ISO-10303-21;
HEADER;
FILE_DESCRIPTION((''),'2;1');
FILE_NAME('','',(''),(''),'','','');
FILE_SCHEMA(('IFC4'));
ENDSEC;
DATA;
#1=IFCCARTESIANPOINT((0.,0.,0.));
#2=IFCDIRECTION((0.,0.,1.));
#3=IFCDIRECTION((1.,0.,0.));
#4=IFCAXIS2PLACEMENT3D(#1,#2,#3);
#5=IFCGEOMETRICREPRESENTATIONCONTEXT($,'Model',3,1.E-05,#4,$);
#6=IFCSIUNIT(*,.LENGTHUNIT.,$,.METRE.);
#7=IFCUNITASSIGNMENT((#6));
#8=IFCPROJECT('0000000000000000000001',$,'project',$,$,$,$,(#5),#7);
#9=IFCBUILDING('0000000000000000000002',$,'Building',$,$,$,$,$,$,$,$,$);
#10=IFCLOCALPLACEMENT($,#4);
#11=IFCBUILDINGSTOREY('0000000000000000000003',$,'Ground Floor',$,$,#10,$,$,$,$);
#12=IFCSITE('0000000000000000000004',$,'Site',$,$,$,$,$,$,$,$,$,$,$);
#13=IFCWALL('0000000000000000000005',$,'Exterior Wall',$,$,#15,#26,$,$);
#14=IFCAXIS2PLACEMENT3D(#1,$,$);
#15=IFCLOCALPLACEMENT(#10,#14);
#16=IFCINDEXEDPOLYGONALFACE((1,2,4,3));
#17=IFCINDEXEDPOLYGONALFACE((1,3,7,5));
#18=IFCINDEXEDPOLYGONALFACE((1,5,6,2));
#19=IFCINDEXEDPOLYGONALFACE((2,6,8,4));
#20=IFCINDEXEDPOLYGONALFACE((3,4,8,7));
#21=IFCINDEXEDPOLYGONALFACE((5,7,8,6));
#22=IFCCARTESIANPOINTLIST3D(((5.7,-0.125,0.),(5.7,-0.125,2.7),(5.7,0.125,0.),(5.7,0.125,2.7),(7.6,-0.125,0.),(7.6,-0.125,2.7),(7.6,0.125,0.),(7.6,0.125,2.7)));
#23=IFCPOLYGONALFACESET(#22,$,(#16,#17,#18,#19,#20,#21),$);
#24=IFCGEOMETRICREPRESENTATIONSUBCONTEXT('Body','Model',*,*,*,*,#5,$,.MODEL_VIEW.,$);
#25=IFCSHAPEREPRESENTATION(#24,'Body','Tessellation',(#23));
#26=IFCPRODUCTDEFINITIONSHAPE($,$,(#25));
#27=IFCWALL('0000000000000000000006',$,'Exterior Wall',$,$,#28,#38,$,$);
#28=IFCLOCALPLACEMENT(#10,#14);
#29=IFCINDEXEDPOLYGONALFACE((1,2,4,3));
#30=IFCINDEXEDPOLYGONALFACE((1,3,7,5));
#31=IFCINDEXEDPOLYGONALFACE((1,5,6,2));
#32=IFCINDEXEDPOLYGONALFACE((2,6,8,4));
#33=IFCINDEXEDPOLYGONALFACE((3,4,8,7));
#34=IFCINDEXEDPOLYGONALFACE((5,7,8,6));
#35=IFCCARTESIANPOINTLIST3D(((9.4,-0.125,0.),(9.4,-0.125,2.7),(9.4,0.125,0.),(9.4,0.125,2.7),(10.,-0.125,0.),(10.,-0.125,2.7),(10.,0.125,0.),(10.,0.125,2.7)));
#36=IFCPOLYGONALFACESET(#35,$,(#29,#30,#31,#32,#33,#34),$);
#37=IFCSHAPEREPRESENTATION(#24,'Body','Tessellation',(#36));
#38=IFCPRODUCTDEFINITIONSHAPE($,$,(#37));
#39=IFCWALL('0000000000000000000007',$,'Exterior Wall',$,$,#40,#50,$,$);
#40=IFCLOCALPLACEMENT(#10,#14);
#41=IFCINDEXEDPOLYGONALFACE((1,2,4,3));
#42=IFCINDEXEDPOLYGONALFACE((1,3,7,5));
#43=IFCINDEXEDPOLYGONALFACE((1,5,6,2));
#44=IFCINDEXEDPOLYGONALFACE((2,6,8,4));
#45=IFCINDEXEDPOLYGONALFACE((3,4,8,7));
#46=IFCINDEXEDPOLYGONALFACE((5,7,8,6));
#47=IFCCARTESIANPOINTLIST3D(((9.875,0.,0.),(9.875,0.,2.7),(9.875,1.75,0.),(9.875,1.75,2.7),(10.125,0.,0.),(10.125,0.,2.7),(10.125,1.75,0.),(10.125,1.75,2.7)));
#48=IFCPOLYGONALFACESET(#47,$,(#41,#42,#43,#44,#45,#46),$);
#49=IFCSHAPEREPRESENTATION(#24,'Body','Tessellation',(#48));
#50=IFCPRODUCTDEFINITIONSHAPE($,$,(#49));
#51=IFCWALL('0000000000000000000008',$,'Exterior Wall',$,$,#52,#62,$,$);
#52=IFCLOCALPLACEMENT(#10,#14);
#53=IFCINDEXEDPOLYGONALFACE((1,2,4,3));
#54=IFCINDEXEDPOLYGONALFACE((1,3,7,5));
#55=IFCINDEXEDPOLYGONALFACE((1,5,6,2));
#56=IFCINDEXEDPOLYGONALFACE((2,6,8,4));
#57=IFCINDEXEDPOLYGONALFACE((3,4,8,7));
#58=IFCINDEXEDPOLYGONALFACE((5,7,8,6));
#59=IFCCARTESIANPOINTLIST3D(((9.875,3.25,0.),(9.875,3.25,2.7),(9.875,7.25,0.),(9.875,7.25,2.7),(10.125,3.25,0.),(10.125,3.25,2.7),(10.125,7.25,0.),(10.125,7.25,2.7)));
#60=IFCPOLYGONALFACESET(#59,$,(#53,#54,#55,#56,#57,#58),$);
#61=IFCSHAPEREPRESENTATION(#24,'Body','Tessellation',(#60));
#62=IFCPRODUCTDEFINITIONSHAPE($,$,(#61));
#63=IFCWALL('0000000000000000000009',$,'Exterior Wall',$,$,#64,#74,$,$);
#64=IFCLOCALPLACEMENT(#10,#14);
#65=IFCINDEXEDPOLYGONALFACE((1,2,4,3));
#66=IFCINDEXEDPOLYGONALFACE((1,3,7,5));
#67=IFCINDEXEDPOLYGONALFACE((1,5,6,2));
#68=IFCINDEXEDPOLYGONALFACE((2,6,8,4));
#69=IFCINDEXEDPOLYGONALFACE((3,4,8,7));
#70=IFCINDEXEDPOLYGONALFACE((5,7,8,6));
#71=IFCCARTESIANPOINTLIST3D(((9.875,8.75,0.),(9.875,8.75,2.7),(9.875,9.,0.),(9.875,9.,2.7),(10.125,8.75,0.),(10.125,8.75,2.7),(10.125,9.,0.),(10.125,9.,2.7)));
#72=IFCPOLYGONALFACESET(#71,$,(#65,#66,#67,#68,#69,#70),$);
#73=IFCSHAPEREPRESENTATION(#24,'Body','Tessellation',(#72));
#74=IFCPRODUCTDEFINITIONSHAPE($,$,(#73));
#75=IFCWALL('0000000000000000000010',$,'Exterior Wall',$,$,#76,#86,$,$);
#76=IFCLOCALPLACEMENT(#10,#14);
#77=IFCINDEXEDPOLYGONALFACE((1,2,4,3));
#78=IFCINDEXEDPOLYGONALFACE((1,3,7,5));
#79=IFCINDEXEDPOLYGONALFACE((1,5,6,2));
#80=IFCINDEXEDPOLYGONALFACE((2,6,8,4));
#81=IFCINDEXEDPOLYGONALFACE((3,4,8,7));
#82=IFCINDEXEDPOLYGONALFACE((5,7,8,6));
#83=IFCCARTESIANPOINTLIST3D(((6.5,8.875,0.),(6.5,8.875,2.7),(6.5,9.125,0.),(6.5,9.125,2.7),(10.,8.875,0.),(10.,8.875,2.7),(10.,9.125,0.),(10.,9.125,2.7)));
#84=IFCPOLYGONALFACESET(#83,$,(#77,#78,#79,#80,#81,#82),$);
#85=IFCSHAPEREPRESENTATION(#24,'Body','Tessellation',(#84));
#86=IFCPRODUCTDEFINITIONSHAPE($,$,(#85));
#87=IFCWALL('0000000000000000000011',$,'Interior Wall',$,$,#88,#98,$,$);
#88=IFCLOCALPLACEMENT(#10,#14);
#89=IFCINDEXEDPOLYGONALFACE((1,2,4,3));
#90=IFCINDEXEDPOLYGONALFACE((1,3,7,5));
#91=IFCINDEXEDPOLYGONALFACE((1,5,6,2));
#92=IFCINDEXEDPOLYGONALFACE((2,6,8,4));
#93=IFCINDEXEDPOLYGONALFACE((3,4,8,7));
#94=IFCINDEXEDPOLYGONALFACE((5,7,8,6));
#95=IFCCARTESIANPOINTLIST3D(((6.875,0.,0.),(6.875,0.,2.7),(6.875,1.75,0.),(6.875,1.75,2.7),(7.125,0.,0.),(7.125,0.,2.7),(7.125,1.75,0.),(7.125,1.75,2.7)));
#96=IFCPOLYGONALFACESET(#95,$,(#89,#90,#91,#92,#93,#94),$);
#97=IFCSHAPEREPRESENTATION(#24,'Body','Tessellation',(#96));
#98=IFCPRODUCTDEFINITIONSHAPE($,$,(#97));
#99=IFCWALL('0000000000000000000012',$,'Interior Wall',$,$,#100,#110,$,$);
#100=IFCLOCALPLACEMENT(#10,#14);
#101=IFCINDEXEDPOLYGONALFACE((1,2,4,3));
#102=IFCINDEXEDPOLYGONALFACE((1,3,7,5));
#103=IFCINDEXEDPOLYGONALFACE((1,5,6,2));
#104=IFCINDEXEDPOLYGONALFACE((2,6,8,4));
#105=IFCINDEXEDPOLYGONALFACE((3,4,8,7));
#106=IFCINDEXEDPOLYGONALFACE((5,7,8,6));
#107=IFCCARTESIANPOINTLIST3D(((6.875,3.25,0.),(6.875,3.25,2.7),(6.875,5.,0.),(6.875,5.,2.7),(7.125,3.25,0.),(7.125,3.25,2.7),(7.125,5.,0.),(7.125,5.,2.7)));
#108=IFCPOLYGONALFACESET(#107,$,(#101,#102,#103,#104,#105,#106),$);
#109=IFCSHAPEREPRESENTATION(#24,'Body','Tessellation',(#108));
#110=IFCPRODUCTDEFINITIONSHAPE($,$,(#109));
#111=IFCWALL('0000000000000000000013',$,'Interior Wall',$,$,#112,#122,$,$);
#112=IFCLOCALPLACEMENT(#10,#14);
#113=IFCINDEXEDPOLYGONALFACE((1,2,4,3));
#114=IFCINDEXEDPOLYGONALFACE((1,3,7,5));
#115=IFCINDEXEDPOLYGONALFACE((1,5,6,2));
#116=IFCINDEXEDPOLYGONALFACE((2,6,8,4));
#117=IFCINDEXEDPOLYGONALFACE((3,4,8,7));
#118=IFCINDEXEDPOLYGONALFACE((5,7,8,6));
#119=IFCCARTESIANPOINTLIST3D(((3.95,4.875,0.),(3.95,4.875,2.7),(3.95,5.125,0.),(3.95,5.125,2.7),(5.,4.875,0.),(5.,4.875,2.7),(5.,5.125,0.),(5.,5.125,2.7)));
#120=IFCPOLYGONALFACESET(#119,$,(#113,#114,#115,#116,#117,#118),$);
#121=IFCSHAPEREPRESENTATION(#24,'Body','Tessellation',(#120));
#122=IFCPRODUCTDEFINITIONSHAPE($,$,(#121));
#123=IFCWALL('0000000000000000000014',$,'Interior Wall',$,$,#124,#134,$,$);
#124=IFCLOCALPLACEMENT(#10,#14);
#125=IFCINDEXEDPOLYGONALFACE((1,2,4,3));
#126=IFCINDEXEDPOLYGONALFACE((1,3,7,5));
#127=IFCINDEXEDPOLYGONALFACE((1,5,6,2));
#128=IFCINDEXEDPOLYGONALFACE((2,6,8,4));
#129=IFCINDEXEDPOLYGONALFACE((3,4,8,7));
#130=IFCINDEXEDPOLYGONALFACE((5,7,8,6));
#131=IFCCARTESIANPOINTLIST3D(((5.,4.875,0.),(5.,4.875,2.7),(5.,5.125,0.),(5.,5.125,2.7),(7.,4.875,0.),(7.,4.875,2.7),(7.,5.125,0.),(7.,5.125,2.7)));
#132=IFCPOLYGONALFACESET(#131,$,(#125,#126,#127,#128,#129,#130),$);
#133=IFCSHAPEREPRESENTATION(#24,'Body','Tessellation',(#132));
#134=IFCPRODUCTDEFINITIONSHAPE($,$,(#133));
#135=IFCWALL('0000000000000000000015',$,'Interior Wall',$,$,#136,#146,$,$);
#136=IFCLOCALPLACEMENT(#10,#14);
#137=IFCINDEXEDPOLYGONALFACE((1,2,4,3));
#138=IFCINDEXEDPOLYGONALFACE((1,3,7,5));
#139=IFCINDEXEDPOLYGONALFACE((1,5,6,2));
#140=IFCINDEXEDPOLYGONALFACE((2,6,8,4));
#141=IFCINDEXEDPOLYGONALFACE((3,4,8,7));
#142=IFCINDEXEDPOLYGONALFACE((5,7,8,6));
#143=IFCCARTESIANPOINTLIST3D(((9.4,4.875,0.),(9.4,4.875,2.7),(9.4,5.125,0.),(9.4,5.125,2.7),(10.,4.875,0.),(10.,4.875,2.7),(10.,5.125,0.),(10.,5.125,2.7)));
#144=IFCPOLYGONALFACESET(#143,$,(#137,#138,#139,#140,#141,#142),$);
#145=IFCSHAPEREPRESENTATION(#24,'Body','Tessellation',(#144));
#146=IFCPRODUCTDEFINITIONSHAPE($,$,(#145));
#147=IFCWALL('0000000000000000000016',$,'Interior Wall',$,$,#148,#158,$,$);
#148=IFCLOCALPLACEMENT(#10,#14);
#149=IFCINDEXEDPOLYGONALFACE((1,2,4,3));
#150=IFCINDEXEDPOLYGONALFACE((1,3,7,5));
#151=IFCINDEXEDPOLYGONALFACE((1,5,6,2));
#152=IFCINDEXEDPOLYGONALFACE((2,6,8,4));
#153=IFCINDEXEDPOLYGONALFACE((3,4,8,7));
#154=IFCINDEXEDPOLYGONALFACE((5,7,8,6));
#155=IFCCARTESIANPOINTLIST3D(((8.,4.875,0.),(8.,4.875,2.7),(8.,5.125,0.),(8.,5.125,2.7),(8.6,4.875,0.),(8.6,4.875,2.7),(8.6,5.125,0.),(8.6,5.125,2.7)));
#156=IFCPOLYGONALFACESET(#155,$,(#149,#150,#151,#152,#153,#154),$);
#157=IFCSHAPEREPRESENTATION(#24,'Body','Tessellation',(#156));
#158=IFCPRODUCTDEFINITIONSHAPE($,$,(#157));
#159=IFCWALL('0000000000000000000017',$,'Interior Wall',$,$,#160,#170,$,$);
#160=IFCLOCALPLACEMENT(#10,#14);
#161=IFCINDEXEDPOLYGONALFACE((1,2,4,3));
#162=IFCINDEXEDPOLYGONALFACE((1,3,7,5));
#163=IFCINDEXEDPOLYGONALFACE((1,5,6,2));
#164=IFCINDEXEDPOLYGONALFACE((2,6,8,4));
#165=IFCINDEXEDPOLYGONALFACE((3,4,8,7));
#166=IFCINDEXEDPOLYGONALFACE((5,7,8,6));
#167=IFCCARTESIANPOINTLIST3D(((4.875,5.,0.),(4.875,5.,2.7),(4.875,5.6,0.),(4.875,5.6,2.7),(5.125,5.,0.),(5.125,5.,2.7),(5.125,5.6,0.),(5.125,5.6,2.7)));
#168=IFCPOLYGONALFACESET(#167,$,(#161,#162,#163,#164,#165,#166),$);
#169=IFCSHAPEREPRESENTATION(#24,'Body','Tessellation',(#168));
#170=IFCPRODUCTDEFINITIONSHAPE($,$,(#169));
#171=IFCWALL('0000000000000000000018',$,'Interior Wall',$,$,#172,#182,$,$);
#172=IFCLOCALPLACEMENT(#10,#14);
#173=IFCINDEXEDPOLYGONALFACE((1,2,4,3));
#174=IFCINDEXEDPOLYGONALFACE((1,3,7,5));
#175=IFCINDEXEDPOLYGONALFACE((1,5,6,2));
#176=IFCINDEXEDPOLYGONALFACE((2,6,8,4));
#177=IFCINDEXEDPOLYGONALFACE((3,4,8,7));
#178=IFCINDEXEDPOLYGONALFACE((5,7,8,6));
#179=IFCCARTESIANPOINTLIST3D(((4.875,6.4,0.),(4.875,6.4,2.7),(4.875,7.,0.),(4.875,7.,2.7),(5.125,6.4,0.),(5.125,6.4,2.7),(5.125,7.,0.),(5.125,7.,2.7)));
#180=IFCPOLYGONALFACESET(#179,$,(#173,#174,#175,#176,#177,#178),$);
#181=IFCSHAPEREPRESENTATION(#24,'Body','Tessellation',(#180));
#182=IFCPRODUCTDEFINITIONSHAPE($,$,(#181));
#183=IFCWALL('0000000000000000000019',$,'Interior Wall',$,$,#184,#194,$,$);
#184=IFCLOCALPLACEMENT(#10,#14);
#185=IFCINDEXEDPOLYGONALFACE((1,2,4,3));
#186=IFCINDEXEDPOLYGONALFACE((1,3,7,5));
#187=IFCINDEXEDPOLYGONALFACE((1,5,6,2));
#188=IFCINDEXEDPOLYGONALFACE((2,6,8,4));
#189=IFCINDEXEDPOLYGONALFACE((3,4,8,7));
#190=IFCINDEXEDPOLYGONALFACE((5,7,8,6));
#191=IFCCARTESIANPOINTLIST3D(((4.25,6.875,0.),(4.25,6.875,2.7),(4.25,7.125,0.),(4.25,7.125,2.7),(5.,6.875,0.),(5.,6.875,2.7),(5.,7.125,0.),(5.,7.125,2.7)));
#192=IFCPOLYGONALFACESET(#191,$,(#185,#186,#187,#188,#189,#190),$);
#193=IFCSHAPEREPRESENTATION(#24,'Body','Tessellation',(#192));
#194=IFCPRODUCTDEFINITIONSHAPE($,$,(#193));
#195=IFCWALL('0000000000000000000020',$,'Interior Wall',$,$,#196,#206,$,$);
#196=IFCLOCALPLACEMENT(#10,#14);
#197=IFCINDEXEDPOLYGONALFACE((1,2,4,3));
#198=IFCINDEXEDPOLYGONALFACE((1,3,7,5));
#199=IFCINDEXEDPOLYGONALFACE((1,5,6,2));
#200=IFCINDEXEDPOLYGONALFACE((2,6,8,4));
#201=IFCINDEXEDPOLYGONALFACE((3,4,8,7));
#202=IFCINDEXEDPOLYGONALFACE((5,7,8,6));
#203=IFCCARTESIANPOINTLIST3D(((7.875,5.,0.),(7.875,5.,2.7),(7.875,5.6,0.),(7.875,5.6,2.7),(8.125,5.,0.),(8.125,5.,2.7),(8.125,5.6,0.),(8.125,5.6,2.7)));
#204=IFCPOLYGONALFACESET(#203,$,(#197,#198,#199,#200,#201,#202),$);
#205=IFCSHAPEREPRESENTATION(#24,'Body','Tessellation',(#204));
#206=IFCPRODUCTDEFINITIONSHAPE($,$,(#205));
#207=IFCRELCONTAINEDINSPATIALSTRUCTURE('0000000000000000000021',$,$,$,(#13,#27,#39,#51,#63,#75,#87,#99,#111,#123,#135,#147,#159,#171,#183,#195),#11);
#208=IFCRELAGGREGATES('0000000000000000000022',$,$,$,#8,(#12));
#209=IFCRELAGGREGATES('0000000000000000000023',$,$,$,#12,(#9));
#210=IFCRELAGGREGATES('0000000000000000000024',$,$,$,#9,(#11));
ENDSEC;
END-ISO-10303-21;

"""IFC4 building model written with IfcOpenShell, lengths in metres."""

from ifc_helpers import new_model, si_unit, frame, origin_with_axes, place, context, subcontext, project, spatial, indexed_curve, outline, extrude, element, save


model = new_model("IFC4")

# Units and contexts
model_context = context("Model", 3, precision=1e-05, world=origin_with_axes())
body_context = subcontext(model_context, "Body", "Model", "MODEL_VIEW")
ifc_project = project(units=[si_unit("LENGTHUNIT", "METRE")], contexts=[model_context])

# Site, building, storey
site = spatial("IfcSite", under=ifc_project, Name="Site")
building = spatial("IfcBuilding", under=site, Name="Building")
storey_placement = place(None, origin_with_axes())
storey = spatial("IfcBuildingStorey", under=building, at=storey_placement, Name="Ground Floor")

# Walls
wall_1_placement = place(storey_placement, frame((5.7, 0.0, 0.0), z_axis=(0.0, 0.0, 1.0), x_axis=(1.0, 0.0, 0.0)))
element("IfcWall", 1, at=wall_1_placement, inside=storey, Name="Exterior Wall", context=body_context, shape_type="SweptSolid", body=[
    extrude(outline(indexed_curve([(0.0, 0.0), (0.0, 0.25), (1.9, 0.25), (1.9, 0.0), (0.0, 0.0)], self_intersect=False)), frame((0.0, -0.125, 0.0), z_axis=(0.0, 0.0, 1.0), x_axis=(1.0, 0.0, 0.0)), (0.0, 0.0, 1.0), 2.7),
])
wall_2_placement = place(storey_placement, frame((9.4, 0.0, 0.0), z_axis=(0.0, 0.0, 1.0), x_axis=(1.0, 0.0, 0.0)))
element("IfcWall", 2, at=wall_2_placement, inside=storey, Name="Exterior Wall", context=body_context, shape_type="SweptSolid", body=[
    extrude(outline(indexed_curve([(0.0, 0.0), (0.0, 0.25), (0.6, 0.25), (0.6, 0.0), (0.0, 0.0)], self_intersect=False)), frame((0.0, -0.125, 0.0), z_axis=(0.0, 0.0, 1.0), x_axis=(1.0, 0.0, 0.0)), (0.0, 0.0, 1.0), 2.7),
])
wall_3_placement = place(storey_placement, frame((10.0, 0.0, 0.0), z_axis=(0.0, 0.0, 1.0), x_axis=(0.0, 1.0, 0.0)))
element("IfcWall", 3, at=wall_3_placement, inside=storey, Name="Exterior Wall", context=body_context, shape_type="SweptSolid", body=[
    extrude(outline(indexed_curve([(0.0, 0.0), (0.0, 0.25), (1.75, 0.25), (1.75, 0.0), (0.0, 0.0)], self_intersect=False)), frame((0.0, -0.125, 0.0), z_axis=(0.0, 0.0, 1.0), x_axis=(1.0, 0.0, 0.0)), (0.0, 0.0, 1.0), 2.7),
])
wall_4_placement = place(storey_placement, frame((10.0, 3.25, 0.0), z_axis=(0.0, 0.0, 1.0), x_axis=(0.0, 1.0, 0.0)))
element("IfcWall", 4, at=wall_4_placement, inside=storey, Name="Exterior Wall", context=body_context, shape_type="SweptSolid", body=[
    extrude(outline(indexed_curve([(0.0, 0.0), (0.0, 0.25), (4.0, 0.25), (4.0, 0.0), (0.0, 0.0)], self_intersect=False)), frame((0.0, -0.125, 0.0), z_axis=(0.0, 0.0, 1.0), x_axis=(1.0, 0.0, 0.0)), (0.0, 0.0, 1.0), 2.7),
])
wall_5_placement = place(storey_placement, frame((10.0, 8.75, 0.0), z_axis=(0.0, 0.0, 1.0), x_axis=(0.0, 1.0, 0.0)))
element("IfcWall", 5, at=wall_5_placement, inside=storey, Name="Exterior Wall", context=body_context, shape_type="SweptSolid", body=[
    extrude(outline(indexed_curve([(0.0, 0.0), (0.0, 0.25), (0.25, 0.25), (0.25, 0.0), (0.0, 0.0)], self_intersect=False)), frame((0.0, -0.125, 0.0), z_axis=(0.0, 0.0, 1.0), x_axis=(1.0, 0.0, 0.0)), (0.0, 0.0, 1.0), 2.7),
])
wall_6_placement = place(storey_placement, frame((10.0, 9.0, 0.0), z_axis=(0.0, 0.0, 1.0), x_axis=(-1.0, 0.0, 0.0)))
element("IfcWall", 6, at=wall_6_placement, inside=storey, Name="Exterior Wall", context=body_context, shape_type="SweptSolid", body=[
    extrude(outline(indexed_curve([(0.0, 0.0), (0.0, 0.25), (3.5, 0.25), (3.5, 0.0), (0.0, 0.0)], self_intersect=False)), frame((0.0, -0.125, 0.0), z_axis=(0.0, 0.0, 1.0), x_axis=(1.0, 0.0, 0.0)), (0.0, 0.0, 1.0), 2.7),
])
for number, where, z_axis, x_axis, name in (
    (7, (7.0, 0.0, 0.0), (0.0, 0.0, 1.0), (0.0, 1.0, 0.0), "Interior Wall"),
    (8, (7.0, 3.25, 0.0), (0.0, 0.0, 1.0), (0.0, 1.0, 0.0), "Interior Wall"),
):
    element("IfcWall", number, at=place(storey_placement, frame(where, z_axis=z_axis, x_axis=x_axis)), inside=storey, Name=name, context=body_context, shape_type="SweptSolid", body=[
        extrude(outline(indexed_curve([(0.0, 0.0), (0.0, 0.25), (1.75, 0.25), (1.75, 0.0), (0.0, 0.0)], self_intersect=False)), frame((0.0, -0.125, 0.0), z_axis=(0.0, 0.0, 1.0), x_axis=(1.0, 0.0, 0.0)), (0.0, 0.0, 1.0), 2.7),
    ])
wall_7_placement = place(storey_placement, frame((5.0, 5.0, 0.0), z_axis=(0.0, 0.0, 1.0), x_axis=(-1.0, 0.0, 0.0)))
element("IfcWall", 9, at=wall_7_placement, inside=storey, Name="Interior Wall", context=body_context, shape_type="SweptSolid", body=[
    extrude(outline(indexed_curve([(0.0, 0.0), (0.0, 0.25), (1.05, 0.25), (1.05, 0.0), (0.0, 0.0)], self_intersect=False)), frame((0.0, -0.125, 0.0), z_axis=(0.0, 0.0, 1.0), x_axis=(1.0, 0.0, 0.0)), (0.0, 0.0, 1.0), 2.7),
])
wall_8_placement = place(storey_placement, frame((7.0, 5.0, 0.0), z_axis=(0.0, 0.0, 1.0), x_axis=(-1.0, 0.0, 0.0)))
element("IfcWall", 10, at=wall_8_placement, inside=storey, Name="Interior Wall", context=body_context, shape_type="SweptSolid", body=[
    extrude(outline(indexed_curve([(0.0, 0.0), (0.0, 0.25), (2.0, 0.25), (2.0, 0.0), (0.0, 0.0)], self_intersect=False)), frame((0.0, -0.125, 0.0), z_axis=(0.0, 0.0, 1.0), x_axis=(1.0, 0.0, 0.0)), (0.0, 0.0, 1.0), 2.7),
])
for number, where, z_axis, x_axis, name in (
    (11, (10.0, 5.0, 0.0), (0.0, 0.0, 1.0), (-1.0, 0.0, 0.0), "Interior Wall"),
    (12, (8.6, 5.0, 0.0), (0.0, 0.0, 1.0), (-1.0, 0.0, 0.0), "Interior Wall"),
    (13, (5.0, 5.0, 0.0), (0.0, 0.0, 1.0), (0.0, 1.0, 0.0), "Interior Wall"),
    (14, (5.0, 6.4, 0.0), (0.0, 0.0, 1.0), (0.0, 1.0, 0.0), "Interior Wall"),
):
    element("IfcWall", number, at=place(storey_placement, frame(where, z_axis=z_axis, x_axis=x_axis)), inside=storey, Name=name, context=body_context, shape_type="SweptSolid", body=[
        extrude(outline(indexed_curve([(0.0, 0.0), (0.0, 0.25), (0.6, 0.25), (0.6, 0.0), (0.0, 0.0)], self_intersect=False)), frame((0.0, -0.125, 0.0), z_axis=(0.0, 0.0, 1.0), x_axis=(1.0, 0.0, 0.0)), (0.0, 0.0, 1.0), 2.7),
    ])
wall_9_placement = place(storey_placement, frame((5.0, 7.0, 0.0), z_axis=(0.0, 0.0, 1.0), x_axis=(-1.0, 0.0, 0.0)))
element("IfcWall", 15, at=wall_9_placement, inside=storey, Name="Interior Wall", context=body_context, shape_type="SweptSolid", body=[
    extrude(outline(indexed_curve([(0.0, 0.0), (0.0, 0.25), (0.75, 0.25), (0.75, 0.0), (0.0, 0.0)], self_intersect=False)), frame((0.0, -0.125, 0.0), z_axis=(0.0, 0.0, 1.0), x_axis=(1.0, 0.0, 0.0)), (0.0, 0.0, 1.0), 2.7),
])
for number, where, z_axis, x_axis, name in (
    (16, (8.0, 5.0, 0.0), (0.0, 0.0, 1.0), (0.0, 1.0, 0.0), "Interior Wall"),
):
    element("IfcWall", number, at=place(storey_placement, frame(where, z_axis=z_axis, x_axis=x_axis)), inside=storey, Name=name, context=body_context, shape_type="SweptSolid", body=[
        extrude(outline(indexed_curve([(0.0, 0.0), (0.0, 0.25), (0.6, 0.25), (0.6, 0.0), (0.0, 0.0)], self_intersect=False)), frame((0.0, -0.125, 0.0), z_axis=(0.0, 0.0, 1.0), x_axis=(1.0, 0.0, 0.0)), (0.0, 0.0, 1.0), 2.7),
    ])

save(model, "model.ifc")
